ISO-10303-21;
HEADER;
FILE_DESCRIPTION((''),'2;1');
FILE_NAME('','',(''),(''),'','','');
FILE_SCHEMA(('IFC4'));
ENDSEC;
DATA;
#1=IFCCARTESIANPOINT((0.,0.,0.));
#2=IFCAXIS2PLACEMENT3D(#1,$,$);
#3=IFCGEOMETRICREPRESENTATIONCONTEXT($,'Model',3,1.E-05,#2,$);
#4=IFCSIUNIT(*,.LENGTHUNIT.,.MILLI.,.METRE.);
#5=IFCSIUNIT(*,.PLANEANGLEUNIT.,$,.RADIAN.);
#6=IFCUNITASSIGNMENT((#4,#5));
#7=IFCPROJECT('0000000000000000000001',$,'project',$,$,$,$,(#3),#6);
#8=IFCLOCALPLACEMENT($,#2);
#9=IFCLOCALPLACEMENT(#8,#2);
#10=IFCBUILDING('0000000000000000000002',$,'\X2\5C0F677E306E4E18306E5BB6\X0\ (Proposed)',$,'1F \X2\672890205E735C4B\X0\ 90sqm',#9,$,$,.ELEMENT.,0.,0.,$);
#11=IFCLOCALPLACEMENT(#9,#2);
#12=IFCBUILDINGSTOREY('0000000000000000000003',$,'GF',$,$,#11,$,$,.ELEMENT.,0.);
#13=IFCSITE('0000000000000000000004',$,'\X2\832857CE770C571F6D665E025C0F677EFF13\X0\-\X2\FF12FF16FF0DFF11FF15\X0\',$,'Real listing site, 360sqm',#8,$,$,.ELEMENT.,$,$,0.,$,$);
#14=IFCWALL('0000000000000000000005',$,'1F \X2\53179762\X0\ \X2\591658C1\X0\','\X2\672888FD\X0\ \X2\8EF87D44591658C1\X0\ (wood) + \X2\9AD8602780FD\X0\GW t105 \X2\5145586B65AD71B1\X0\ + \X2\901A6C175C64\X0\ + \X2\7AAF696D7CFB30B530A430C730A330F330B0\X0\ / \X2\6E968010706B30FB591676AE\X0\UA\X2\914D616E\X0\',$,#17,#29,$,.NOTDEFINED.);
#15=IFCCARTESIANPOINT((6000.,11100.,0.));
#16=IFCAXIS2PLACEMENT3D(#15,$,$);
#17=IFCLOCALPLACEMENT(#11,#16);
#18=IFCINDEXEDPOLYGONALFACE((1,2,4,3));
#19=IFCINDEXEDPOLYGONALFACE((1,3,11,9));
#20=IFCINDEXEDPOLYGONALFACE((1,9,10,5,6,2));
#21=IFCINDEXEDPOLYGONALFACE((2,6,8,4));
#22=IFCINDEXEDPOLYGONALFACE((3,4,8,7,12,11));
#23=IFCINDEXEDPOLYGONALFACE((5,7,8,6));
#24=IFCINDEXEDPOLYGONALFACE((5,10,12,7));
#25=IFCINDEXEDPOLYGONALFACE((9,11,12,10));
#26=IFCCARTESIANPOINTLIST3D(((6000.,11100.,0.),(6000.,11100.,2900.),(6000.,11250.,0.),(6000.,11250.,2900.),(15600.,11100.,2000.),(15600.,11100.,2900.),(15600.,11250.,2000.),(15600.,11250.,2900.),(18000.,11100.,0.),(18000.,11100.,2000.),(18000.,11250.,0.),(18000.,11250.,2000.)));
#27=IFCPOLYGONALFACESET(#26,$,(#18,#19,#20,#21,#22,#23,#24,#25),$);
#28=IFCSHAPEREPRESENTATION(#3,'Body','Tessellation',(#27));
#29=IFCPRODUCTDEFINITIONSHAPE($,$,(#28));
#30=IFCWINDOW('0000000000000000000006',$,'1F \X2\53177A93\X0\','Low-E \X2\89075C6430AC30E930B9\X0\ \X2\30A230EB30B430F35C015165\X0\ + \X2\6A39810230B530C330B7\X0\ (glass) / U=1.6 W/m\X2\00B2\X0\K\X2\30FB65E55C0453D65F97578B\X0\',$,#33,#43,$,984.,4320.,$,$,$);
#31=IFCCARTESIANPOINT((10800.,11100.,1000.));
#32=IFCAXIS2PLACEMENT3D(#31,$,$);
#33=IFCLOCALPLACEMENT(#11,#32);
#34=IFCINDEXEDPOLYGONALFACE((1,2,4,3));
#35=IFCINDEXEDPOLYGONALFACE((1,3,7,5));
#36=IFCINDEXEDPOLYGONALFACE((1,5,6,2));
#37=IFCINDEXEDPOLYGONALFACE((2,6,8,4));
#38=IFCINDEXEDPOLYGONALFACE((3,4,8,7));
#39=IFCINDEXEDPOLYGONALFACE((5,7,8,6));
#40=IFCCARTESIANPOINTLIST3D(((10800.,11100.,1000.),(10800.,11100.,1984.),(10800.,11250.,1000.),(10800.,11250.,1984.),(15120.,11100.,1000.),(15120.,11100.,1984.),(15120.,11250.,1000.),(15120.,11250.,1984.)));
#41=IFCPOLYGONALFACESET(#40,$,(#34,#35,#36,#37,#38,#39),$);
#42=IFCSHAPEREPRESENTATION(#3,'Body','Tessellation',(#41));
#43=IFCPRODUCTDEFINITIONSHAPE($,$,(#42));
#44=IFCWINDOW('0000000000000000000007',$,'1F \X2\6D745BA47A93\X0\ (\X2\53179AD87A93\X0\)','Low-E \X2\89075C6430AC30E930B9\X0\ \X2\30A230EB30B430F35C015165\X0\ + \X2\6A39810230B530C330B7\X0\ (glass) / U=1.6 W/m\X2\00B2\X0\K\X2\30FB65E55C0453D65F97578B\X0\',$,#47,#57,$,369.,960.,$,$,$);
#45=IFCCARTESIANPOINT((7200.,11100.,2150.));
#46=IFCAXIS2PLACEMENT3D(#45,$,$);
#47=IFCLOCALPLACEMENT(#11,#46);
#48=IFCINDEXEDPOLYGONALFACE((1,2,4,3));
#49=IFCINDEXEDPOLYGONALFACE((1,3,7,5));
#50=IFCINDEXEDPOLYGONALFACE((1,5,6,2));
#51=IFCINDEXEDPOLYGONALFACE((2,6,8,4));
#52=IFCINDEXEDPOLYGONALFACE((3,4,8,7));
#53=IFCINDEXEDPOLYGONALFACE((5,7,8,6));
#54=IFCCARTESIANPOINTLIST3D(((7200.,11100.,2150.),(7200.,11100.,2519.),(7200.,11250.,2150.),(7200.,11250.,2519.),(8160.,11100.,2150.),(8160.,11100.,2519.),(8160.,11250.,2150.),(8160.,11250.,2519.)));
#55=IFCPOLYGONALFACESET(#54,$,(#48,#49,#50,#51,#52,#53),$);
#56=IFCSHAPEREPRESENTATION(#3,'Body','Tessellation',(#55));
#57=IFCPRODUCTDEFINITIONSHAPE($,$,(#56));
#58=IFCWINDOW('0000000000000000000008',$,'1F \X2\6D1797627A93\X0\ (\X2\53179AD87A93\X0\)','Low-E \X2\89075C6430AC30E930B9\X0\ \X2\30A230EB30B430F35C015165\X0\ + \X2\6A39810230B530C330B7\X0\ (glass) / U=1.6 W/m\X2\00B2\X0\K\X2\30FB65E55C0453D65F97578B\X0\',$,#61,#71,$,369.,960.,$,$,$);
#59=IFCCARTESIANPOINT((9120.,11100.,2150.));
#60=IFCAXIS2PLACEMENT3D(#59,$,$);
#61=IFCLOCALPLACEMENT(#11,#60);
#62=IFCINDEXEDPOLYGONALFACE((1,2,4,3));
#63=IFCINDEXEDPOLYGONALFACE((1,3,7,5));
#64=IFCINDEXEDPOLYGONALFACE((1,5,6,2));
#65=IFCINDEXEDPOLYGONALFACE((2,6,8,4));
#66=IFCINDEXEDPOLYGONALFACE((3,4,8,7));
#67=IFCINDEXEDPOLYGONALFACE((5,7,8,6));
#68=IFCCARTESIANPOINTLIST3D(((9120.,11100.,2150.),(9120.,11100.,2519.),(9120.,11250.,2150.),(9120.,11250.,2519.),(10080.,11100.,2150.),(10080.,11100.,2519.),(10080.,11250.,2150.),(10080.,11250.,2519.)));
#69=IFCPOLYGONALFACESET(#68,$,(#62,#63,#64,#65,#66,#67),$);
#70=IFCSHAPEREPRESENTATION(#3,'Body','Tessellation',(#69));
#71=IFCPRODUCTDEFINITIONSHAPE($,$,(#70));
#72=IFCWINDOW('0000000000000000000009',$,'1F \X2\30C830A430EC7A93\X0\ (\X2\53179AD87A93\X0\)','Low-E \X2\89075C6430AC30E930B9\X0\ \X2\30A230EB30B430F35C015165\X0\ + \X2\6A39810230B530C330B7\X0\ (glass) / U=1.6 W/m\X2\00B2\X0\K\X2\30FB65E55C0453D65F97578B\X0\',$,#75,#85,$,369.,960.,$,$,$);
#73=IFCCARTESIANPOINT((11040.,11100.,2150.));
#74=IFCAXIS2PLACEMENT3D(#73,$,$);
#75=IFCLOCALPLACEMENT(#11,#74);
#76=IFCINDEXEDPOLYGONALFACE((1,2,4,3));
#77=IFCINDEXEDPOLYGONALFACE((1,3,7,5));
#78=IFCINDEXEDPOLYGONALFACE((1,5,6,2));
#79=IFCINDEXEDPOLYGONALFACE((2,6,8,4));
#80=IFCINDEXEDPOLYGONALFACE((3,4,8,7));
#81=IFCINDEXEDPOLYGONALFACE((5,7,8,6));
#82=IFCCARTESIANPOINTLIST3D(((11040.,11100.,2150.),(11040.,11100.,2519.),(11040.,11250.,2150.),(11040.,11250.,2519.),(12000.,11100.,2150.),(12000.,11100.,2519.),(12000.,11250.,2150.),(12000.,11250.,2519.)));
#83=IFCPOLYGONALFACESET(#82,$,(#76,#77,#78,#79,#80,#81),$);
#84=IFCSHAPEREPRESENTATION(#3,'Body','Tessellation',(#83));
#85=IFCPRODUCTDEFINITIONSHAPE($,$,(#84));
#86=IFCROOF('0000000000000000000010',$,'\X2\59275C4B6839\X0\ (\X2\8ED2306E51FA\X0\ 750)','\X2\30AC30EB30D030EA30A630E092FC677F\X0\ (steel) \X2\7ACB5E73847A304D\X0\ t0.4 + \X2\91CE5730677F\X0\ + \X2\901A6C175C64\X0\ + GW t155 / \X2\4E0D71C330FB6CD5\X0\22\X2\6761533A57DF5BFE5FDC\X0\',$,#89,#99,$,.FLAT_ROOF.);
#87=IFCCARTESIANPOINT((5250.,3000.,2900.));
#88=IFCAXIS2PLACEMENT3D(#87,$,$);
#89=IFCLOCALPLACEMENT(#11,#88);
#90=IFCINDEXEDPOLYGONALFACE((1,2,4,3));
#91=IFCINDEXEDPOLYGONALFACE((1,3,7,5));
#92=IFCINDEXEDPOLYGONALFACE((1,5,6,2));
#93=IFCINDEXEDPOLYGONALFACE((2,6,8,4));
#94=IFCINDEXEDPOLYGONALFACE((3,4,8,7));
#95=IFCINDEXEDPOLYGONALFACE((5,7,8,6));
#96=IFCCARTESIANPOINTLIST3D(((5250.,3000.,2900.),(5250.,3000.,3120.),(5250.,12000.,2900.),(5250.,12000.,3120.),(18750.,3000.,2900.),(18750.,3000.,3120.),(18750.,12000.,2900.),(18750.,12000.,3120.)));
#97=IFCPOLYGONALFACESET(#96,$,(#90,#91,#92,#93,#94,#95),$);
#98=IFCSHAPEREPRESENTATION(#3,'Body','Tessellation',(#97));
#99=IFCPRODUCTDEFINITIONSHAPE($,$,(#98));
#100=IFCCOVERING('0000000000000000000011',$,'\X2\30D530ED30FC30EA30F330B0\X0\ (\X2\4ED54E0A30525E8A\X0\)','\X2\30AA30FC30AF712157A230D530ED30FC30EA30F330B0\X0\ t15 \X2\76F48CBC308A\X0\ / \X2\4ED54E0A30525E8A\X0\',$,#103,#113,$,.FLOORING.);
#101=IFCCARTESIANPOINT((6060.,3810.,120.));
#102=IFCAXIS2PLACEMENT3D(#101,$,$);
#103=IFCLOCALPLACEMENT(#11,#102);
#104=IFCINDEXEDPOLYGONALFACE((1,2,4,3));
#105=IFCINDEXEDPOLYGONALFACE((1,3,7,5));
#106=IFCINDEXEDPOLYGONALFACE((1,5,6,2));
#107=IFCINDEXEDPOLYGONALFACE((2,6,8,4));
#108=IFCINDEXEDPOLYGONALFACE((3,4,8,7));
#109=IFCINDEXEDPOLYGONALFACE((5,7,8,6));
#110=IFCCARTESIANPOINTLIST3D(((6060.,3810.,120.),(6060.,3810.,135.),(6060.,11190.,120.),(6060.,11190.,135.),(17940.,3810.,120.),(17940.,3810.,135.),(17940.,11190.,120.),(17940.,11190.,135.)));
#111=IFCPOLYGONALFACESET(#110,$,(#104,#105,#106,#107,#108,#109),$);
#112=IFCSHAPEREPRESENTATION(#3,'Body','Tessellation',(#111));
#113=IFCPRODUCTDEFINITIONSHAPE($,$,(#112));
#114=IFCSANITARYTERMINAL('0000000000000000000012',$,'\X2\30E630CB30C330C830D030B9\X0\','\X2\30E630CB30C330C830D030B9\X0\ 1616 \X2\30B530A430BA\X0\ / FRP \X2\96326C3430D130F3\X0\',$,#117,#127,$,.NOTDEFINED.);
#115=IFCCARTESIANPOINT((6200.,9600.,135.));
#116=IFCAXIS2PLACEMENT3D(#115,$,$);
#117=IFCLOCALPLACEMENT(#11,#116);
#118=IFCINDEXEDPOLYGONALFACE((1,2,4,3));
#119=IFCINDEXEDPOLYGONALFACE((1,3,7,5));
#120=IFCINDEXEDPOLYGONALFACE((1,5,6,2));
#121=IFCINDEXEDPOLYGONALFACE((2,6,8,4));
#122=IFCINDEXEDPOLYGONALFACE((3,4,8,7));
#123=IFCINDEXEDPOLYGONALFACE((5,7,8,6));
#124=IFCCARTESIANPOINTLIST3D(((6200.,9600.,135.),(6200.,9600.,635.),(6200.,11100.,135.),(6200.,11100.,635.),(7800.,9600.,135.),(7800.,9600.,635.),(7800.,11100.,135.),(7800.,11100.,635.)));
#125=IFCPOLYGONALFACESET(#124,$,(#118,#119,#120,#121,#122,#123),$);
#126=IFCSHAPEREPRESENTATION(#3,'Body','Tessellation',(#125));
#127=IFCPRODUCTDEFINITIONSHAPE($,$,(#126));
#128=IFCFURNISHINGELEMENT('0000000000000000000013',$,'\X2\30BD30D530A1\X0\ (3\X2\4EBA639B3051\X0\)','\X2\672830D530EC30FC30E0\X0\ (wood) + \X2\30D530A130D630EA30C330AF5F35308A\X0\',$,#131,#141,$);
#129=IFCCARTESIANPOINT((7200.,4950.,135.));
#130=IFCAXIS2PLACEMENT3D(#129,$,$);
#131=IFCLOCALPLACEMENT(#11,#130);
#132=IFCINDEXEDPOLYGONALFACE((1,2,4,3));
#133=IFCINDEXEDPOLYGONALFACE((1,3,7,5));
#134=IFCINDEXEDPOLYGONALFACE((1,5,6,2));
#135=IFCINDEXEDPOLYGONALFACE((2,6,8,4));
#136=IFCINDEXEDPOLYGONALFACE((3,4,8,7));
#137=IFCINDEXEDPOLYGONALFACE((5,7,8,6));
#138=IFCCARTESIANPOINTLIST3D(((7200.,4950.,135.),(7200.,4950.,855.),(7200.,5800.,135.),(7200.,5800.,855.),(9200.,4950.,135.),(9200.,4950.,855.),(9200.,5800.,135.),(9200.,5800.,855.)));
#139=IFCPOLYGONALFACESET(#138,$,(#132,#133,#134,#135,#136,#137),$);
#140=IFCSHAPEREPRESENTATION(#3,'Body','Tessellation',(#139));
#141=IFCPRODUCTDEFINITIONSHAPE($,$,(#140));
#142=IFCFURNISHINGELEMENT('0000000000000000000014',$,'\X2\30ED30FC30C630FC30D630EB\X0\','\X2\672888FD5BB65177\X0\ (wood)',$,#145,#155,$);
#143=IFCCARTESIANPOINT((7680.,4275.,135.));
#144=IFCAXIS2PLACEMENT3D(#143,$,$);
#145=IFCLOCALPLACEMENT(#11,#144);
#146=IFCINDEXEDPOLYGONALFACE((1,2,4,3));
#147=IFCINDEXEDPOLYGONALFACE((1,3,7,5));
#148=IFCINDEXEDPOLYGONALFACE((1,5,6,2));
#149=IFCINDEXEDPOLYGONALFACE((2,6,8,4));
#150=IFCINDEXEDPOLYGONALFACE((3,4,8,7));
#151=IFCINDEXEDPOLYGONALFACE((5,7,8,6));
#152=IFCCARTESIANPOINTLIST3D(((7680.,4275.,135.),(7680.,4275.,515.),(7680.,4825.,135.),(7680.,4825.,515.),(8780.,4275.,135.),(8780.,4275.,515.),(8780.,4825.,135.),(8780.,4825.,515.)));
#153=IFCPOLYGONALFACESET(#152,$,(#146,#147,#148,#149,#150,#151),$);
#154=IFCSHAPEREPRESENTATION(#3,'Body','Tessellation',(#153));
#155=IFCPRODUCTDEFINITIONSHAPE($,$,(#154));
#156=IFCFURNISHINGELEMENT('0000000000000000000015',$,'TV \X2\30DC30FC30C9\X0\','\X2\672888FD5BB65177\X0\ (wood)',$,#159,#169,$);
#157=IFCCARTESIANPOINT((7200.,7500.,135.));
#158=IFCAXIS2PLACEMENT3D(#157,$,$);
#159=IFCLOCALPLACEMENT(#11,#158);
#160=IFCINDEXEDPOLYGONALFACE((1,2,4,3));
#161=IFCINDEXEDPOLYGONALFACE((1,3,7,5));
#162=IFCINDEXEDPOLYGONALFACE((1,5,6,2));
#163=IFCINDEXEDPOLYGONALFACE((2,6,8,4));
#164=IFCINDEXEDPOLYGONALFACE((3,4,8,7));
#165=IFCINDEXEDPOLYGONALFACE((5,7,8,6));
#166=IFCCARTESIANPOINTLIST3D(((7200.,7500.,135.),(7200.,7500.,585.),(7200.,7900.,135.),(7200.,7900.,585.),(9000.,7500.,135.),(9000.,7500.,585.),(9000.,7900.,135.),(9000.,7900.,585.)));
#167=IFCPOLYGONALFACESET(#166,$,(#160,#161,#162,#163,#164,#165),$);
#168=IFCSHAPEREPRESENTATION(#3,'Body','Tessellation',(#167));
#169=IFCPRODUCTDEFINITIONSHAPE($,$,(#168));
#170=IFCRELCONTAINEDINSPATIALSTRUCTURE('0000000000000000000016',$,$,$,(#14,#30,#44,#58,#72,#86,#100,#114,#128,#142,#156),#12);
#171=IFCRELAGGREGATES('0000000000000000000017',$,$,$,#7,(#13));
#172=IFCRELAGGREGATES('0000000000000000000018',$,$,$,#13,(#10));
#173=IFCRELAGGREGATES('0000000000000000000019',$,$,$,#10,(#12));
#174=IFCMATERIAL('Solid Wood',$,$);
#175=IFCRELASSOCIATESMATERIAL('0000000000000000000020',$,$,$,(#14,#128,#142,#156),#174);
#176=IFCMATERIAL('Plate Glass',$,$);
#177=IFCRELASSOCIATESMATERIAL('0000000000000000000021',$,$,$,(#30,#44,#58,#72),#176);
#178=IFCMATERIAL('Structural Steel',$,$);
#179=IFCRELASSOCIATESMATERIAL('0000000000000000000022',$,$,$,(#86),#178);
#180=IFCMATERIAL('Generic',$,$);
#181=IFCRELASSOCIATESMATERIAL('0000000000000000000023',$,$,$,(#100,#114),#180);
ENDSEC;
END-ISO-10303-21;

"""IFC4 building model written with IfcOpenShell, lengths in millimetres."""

from ifc_helpers import new_model, si_unit, frame, frame_2d, origin, place, context, project, spatial, rectangle, extrude, material, element, fill, save


model = new_model("IFC4")

# Units and contexts
model_context = context("Model", 3, precision=1e-05, world=origin())
ifc_project = project(units=[si_unit("LENGTHUNIT", "METRE", prefix="MILLI"), si_unit("PLANEANGLEUNIT", "RADIAN")], contexts=[model_context])

# Site, building, storey
site_placement = place(None, origin())
site = spatial("IfcSite", under=ifc_project, at=site_placement, Name="茨城県土浦市小松３-２６－１５", ObjectType="Real listing site, 360sqm", CompositionType="ELEMENT", RefElevation=0.0)
building_placement = place(site_placement, origin())
building = spatial("IfcBuilding", under=site, at=building_placement, Name="小松の丘の家 (Proposed)", ObjectType="1F 木造平屋 90sqm", CompositionType="ELEMENT", ElevationOfRefHeight=0.0, ElevationOfTerrain=0.0)
storey_placement = place(building_placement, origin())
storey = spatial("IfcBuildingStorey", under=building, at=storey_placement, Name="GF", CompositionType="ELEMENT", Elevation=0.0)

# Shared definitions
ifc_material_1 = material(Name="Solid Wood")

# Shared definitions
ifc_material_2 = material(Name="Plate Glass")

# Wall, openings, windows
wall_1_placement = place(storey_placement, frame((6000.0, 11100.0, 0.0)))
wall_1 = element("IfcWall", 1, at=wall_1_placement, inside=storey, material=ifc_material_1, Name="1F 北面 外壁", Description="木製 軸組外壁 (wood) + 高性能GW t105 充填断熱 + 通気層 + 窯業系サイディング / 準耐火・外皮UA配慮", PredefinedType="NOTDEFINED", context=model_context, shape_type="SweptSolid", body=[
    extrude(rectangle(XDim=12000.0, YDim=150.0, at=frame_2d((6000.0, 75.0))), frame((6000.0, 11100.0, 0.0)), (0.0, 0.0, 1.0), 2900.0),
])
opening_1_placement = place(storey_placement, frame((10800.0, 11100.0, 1000.0)))
opening_1 = element("IfcOpeningElement", 2, at=opening_1_placement, cuts=wall_1, PredefinedType="NOTDEFINED", context=model_context, shape_type="SweptSolid", body=[
    extrude(rectangle(XDim=4320.0, YDim=150.0, at=frame_2d((2160.0, 75.0))), frame((10800.0, 11100.0, 1000.0)), (0.0, 0.0, 1.0), 984.0),
])
opening_2_placement = place(storey_placement, frame((7200.0, 11100.0, 2150.0)))
opening_2 = element("IfcOpeningElement", 3, at=opening_2_placement, cuts=wall_1, PredefinedType="NOTDEFINED", context=model_context, shape_type="SweptSolid", body=[
    extrude(rectangle(XDim=960.0, YDim=150.0, at=frame_2d((480.0, 75.0))), frame((7200.0, 11100.0, 2150.0)), (0.0, 0.0, 1.0), 369.0),
])
opening_3_placement = place(storey_placement, frame((9120.0, 11100.0, 2150.0)))
opening_3 = element("IfcOpeningElement", 4, at=opening_3_placement, cuts=wall_1, PredefinedType="NOTDEFINED", context=model_context, shape_type="SweptSolid", body=[
    extrude(rectangle(XDim=960.0, YDim=150.0, at=frame_2d((480.0, 75.0))), frame((9120.0, 11100.0, 2150.0)), (0.0, 0.0, 1.0), 369.0),
])
opening_4_placement = place(storey_placement, frame((11040.0, 11100.0, 2150.0)))
opening_4 = element("IfcOpeningElement", 5, at=opening_4_placement, cuts=wall_1, PredefinedType="NOTDEFINED", context=model_context, shape_type="SweptSolid", body=[
    extrude(rectangle(XDim=960.0, YDim=150.0, at=frame_2d((480.0, 75.0))), frame((11040.0, 11100.0, 2150.0)), (0.0, 0.0, 1.0), 369.0),
])
window_1_placement = place(storey_placement, frame((10800.0, 11100.0, 1000.0)))
window_1 = element("IfcWindow", 6, at=window_1_placement, inside=storey, material=ifc_material_2, Name="1F 北窓", Description="Low-E 複層ガラス アルゴン封入 + 樹脂サッシ (glass) / U=1.6 W/m²K・日射取得型", OverallHeight=984.0, OverallWidth=4320.0, context=model_context, shape_type="SweptSolid", body=[
    extrude(rectangle(XDim=4320.0, YDim=150.0, at=frame_2d((2160.0, 75.0))), frame((10800.0, 11100.0, 1000.0)), (0.0, 0.0, 1.0), 984.0),
])
fill(opening_1, window_1)
window_2_placement = place(storey_placement, frame((7200.0, 11100.0, 2150.0)))
window_2 = element("IfcWindow", 7, at=window_2_placement, inside=storey, material=ifc_material_2, Name="1F 浴室窓 (北高窓)", Description="Low-E 複層ガラス アルゴン封入 + 樹脂サッシ (glass) / U=1.6 W/m²K・日射取得型", OverallHeight=369.0, OverallWidth=960.0, context=model_context, shape_type="SweptSolid", body=[
    extrude(rectangle(XDim=960.0, YDim=150.0, at=frame_2d((480.0, 75.0))), frame((7200.0, 11100.0, 2150.0)), (0.0, 0.0, 1.0), 369.0),
])
fill(opening_2, window_2)
window_3_placement = place(storey_placement, frame((9120.0, 11100.0, 2150.0)))
window_3 = element("IfcWindow", 8, at=window_3_placement, inside=storey, material=ifc_material_2, Name="1F 洗面窓 (北高窓)", Description="Low-E 複層ガラス アルゴン封入 + 樹脂サッシ (glass) / U=1.6 W/m²K・日射取得型", OverallHeight=369.0, OverallWidth=960.0, context=model_context, shape_type="SweptSolid", body=[
    extrude(rectangle(XDim=960.0, YDim=150.0, at=frame_2d((480.0, 75.0))), frame((9120.0, 11100.0, 2150.0)), (0.0, 0.0, 1.0), 369.0),
])
fill(opening_3, window_3)
window_4_placement = place(storey_placement, frame((11040.0, 11100.0, 2150.0)))
window_4 = element("IfcWindow", 9, at=window_4_placement, inside=storey, material=ifc_material_2, Name="1F トイレ窓 (北高窓)", Description="Low-E 複層ガラス アルゴン封入 + 樹脂サッシ (glass) / U=1.6 W/m²K・日射取得型", OverallHeight=369.0, OverallWidth=960.0, context=model_context, shape_type="SweptSolid", body=[
    extrude(rectangle(XDim=960.0, YDim=150.0, at=frame_2d((480.0, 75.0))), frame((11040.0, 11100.0, 2150.0)), (0.0, 0.0, 1.0), 369.0),
])
fill(opening_4, window_4)

# Roof
ifc_material_3 = material(Name="Structural Steel")
roof_placement = place(storey_placement, frame((5250.0, 3000.0, 2900.0)))
element("IfcRoof", 10, at=roof_placement, inside=storey, material=ifc_material_3, Name="大屋根 (軒の出 750)", Description="ガルバリウム鋼板 (steel) 立平葺き t0.4 + 野地板 + 通気層 + GW t155 / 不燃・法22条区域対応", PredefinedType="FLAT_ROOF", context=model_context, shape_type="SweptSolid", body=[
    extrude(rectangle(XDim=13500.0, YDim=9000.0, at=frame_2d((6750.0, 4500.0))), frame((5250.0, 3000.0, 2900.0)), (0.0, 0.0, 1.0), 220.0),
])

# Covering
ifc_material_4 = material(Name="Generic")
covering_placement = place(storey_placement, frame((6060.0, 3810.0, 120.0)))
element("IfcCovering", 11, at=covering_placement, inside=storey, material=ifc_material_4, Name="フローリング (仕上げ床)", Description="オーク無垢フローリング t15 直貼り / 仕上げ床", PredefinedType="FLOORING", context=model_context, shape_type="SweptSolid", body=[
    extrude(rectangle(XDim=11880.0, YDim=7380.0, at=frame_2d((5940.0, 3690.0))), frame((6060.0, 3810.0, 120.0)), (0.0, 0.0, 1.0), 15.0),
])

# Sanitary terminal
sanitary_terminal_placement = place(storey_placement, frame((6200.0, 9600.0, 135.0)))
element("IfcSanitaryTerminal", 12, at=sanitary_terminal_placement, inside=storey, material=ifc_material_4, Name="ユニットバス", Description="ユニットバス 1616 サイズ / FRP 防水パン", PredefinedType="NOTDEFINED", context=model_context, shape_type="SweptSolid", body=[
    extrude(rectangle(XDim=1600.0, YDim=1500.0, at=frame_2d((800.0, 750.0))), frame((6200.0, 9600.0, 135.0)), (0.0, 0.0, 1.0), 500.0),
])

# Furnishing elements
furnishing_1_placement = place(storey_placement, frame((7200.0, 4950.0, 135.0)))
element("IfcFurnishingElement", 13, at=furnishing_1_placement, inside=storey, material=ifc_material_1, Name="ソファ (3人掛け)", Description="木フレーム (wood) + ファブリック張り", context=model_context, shape_type="SweptSolid", body=[
    extrude(rectangle(XDim=2000.0, YDim=850.0, at=frame_2d((1000.0, 425.0))), frame((7200.0, 4950.0, 135.0)), (0.0, 0.0, 1.0), 720.0),
])
furnishing_2_placement = place(storey_placement, frame((7680.0, 4275.0, 135.0)))
element("IfcFurnishingElement", 14, at=furnishing_2_placement, inside=storey, material=ifc_material_1, Name="ローテーブル", Description="木製家具 (wood)", context=model_context, shape_type="SweptSolid", body=[
    extrude(rectangle(XDim=1100.0, YDim=550.0, at=frame_2d((550.0, 275.0))), frame((7680.0, 4275.0, 135.0)), (0.0, 0.0, 1.0), 380.0),
])
furnishing_3_placement = place(storey_placement, frame((7200.0, 7500.0, 135.0)))
element("IfcFurnishingElement", 15, at=furnishing_3_placement, inside=storey, material=ifc_material_1, Name="TV ボード", Description="木製家具 (wood)", context=model_context, shape_type="SweptSolid", body=[
    extrude(rectangle(XDim=1800.0, YDim=400.0, at=frame_2d((900.0, 200.0))), frame((7200.0, 7500.0, 135.0)), (0.0, 0.0, 1.0), 450.0),
])

save(model, "model.ifc")
